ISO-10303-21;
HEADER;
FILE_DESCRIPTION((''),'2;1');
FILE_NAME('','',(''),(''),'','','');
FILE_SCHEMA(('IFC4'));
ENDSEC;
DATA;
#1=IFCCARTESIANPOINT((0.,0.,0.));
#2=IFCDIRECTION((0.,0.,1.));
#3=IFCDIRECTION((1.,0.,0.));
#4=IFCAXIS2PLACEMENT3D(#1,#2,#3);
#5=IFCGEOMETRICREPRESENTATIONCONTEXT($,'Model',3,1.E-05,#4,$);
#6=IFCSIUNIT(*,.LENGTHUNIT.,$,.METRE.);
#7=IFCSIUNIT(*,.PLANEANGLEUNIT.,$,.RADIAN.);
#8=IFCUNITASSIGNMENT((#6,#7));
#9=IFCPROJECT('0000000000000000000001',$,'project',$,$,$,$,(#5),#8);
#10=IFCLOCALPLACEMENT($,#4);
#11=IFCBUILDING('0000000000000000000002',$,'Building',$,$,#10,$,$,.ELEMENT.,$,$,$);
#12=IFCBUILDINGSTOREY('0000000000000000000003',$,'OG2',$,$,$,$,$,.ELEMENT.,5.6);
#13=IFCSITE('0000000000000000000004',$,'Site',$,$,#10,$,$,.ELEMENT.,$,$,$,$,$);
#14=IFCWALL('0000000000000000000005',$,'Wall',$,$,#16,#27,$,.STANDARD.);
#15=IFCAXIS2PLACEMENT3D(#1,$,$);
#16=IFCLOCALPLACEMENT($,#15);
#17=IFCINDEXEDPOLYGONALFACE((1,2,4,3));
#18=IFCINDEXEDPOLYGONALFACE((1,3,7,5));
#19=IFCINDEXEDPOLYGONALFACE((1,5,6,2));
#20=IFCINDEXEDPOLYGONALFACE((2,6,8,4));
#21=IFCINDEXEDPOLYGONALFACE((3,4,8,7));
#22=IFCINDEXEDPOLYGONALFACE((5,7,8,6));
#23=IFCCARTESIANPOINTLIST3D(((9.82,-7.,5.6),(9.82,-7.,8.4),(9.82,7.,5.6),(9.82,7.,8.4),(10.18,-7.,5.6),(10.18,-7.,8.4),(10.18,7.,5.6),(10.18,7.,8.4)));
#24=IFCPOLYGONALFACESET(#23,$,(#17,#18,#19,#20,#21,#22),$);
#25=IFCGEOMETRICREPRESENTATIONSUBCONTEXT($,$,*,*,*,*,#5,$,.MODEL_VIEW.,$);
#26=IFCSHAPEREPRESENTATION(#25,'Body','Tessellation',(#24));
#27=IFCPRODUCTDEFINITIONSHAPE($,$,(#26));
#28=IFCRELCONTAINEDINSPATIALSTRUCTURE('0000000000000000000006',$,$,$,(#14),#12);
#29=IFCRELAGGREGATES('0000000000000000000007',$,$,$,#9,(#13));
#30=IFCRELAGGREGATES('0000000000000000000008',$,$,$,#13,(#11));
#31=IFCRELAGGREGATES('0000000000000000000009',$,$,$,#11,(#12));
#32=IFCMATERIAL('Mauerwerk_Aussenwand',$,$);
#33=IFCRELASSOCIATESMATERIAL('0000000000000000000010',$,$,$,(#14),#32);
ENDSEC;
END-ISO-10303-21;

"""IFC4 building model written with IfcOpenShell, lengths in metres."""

from ifc_helpers import new_model, si_unit, frame, frame_2d, origin, origin_with_axes, place, context, subcontext, project, spatial, rectangle, extrude, material, element, save


model = new_model("IFC4")

# Units and contexts
model_context = context("Model", 3, precision=1e-05, world=origin_with_axes())
sub_context = subcontext(model_context, None, None, "MODEL_VIEW")
ifc_project = project(units=[si_unit("LENGTHUNIT", "METRE"), si_unit("PLANEANGLEUNIT", "RADIAN")], contexts=[model_context])

# Site, building, storey
placement_1 = place(None, origin_with_axes())
site = spatial("IfcSite", under=ifc_project, at=placement_1, Name="Site", CompositionType="ELEMENT")
building = spatial("IfcBuilding", under=site, at=placement_1, Name="Building", CompositionType="ELEMENT")
storey = spatial("IfcBuildingStorey", under=building, Name="OG2", CompositionType="ELEMENT", Elevation=5.6)

# Wall
ifc_material = material(Name="Mauerwerk_Aussenwand")
placement_2 = place(None, origin_with_axes())
placement_3 = place(placement_2, frame((0.0, 0.0, 5.6)))
wall_placement = place(placement_3, frame((10.0, -7.0, 0.0), x_axis=(0.0, 1.0, 0.0)))
element("IfcWall", 1, at=wall_placement, inside=storey, material=ifc_material, Name="Wall", PredefinedType="STANDARD", context=sub_context, shape_type="SweptSolid", body=[
    extrude(rectangle(XDim=14.0, YDim=0.36, at=frame_2d((7.0, 0.0))), origin(), (0.0, 0.0, 1.0), 2.8),
])

save(model, "model.ifc")
